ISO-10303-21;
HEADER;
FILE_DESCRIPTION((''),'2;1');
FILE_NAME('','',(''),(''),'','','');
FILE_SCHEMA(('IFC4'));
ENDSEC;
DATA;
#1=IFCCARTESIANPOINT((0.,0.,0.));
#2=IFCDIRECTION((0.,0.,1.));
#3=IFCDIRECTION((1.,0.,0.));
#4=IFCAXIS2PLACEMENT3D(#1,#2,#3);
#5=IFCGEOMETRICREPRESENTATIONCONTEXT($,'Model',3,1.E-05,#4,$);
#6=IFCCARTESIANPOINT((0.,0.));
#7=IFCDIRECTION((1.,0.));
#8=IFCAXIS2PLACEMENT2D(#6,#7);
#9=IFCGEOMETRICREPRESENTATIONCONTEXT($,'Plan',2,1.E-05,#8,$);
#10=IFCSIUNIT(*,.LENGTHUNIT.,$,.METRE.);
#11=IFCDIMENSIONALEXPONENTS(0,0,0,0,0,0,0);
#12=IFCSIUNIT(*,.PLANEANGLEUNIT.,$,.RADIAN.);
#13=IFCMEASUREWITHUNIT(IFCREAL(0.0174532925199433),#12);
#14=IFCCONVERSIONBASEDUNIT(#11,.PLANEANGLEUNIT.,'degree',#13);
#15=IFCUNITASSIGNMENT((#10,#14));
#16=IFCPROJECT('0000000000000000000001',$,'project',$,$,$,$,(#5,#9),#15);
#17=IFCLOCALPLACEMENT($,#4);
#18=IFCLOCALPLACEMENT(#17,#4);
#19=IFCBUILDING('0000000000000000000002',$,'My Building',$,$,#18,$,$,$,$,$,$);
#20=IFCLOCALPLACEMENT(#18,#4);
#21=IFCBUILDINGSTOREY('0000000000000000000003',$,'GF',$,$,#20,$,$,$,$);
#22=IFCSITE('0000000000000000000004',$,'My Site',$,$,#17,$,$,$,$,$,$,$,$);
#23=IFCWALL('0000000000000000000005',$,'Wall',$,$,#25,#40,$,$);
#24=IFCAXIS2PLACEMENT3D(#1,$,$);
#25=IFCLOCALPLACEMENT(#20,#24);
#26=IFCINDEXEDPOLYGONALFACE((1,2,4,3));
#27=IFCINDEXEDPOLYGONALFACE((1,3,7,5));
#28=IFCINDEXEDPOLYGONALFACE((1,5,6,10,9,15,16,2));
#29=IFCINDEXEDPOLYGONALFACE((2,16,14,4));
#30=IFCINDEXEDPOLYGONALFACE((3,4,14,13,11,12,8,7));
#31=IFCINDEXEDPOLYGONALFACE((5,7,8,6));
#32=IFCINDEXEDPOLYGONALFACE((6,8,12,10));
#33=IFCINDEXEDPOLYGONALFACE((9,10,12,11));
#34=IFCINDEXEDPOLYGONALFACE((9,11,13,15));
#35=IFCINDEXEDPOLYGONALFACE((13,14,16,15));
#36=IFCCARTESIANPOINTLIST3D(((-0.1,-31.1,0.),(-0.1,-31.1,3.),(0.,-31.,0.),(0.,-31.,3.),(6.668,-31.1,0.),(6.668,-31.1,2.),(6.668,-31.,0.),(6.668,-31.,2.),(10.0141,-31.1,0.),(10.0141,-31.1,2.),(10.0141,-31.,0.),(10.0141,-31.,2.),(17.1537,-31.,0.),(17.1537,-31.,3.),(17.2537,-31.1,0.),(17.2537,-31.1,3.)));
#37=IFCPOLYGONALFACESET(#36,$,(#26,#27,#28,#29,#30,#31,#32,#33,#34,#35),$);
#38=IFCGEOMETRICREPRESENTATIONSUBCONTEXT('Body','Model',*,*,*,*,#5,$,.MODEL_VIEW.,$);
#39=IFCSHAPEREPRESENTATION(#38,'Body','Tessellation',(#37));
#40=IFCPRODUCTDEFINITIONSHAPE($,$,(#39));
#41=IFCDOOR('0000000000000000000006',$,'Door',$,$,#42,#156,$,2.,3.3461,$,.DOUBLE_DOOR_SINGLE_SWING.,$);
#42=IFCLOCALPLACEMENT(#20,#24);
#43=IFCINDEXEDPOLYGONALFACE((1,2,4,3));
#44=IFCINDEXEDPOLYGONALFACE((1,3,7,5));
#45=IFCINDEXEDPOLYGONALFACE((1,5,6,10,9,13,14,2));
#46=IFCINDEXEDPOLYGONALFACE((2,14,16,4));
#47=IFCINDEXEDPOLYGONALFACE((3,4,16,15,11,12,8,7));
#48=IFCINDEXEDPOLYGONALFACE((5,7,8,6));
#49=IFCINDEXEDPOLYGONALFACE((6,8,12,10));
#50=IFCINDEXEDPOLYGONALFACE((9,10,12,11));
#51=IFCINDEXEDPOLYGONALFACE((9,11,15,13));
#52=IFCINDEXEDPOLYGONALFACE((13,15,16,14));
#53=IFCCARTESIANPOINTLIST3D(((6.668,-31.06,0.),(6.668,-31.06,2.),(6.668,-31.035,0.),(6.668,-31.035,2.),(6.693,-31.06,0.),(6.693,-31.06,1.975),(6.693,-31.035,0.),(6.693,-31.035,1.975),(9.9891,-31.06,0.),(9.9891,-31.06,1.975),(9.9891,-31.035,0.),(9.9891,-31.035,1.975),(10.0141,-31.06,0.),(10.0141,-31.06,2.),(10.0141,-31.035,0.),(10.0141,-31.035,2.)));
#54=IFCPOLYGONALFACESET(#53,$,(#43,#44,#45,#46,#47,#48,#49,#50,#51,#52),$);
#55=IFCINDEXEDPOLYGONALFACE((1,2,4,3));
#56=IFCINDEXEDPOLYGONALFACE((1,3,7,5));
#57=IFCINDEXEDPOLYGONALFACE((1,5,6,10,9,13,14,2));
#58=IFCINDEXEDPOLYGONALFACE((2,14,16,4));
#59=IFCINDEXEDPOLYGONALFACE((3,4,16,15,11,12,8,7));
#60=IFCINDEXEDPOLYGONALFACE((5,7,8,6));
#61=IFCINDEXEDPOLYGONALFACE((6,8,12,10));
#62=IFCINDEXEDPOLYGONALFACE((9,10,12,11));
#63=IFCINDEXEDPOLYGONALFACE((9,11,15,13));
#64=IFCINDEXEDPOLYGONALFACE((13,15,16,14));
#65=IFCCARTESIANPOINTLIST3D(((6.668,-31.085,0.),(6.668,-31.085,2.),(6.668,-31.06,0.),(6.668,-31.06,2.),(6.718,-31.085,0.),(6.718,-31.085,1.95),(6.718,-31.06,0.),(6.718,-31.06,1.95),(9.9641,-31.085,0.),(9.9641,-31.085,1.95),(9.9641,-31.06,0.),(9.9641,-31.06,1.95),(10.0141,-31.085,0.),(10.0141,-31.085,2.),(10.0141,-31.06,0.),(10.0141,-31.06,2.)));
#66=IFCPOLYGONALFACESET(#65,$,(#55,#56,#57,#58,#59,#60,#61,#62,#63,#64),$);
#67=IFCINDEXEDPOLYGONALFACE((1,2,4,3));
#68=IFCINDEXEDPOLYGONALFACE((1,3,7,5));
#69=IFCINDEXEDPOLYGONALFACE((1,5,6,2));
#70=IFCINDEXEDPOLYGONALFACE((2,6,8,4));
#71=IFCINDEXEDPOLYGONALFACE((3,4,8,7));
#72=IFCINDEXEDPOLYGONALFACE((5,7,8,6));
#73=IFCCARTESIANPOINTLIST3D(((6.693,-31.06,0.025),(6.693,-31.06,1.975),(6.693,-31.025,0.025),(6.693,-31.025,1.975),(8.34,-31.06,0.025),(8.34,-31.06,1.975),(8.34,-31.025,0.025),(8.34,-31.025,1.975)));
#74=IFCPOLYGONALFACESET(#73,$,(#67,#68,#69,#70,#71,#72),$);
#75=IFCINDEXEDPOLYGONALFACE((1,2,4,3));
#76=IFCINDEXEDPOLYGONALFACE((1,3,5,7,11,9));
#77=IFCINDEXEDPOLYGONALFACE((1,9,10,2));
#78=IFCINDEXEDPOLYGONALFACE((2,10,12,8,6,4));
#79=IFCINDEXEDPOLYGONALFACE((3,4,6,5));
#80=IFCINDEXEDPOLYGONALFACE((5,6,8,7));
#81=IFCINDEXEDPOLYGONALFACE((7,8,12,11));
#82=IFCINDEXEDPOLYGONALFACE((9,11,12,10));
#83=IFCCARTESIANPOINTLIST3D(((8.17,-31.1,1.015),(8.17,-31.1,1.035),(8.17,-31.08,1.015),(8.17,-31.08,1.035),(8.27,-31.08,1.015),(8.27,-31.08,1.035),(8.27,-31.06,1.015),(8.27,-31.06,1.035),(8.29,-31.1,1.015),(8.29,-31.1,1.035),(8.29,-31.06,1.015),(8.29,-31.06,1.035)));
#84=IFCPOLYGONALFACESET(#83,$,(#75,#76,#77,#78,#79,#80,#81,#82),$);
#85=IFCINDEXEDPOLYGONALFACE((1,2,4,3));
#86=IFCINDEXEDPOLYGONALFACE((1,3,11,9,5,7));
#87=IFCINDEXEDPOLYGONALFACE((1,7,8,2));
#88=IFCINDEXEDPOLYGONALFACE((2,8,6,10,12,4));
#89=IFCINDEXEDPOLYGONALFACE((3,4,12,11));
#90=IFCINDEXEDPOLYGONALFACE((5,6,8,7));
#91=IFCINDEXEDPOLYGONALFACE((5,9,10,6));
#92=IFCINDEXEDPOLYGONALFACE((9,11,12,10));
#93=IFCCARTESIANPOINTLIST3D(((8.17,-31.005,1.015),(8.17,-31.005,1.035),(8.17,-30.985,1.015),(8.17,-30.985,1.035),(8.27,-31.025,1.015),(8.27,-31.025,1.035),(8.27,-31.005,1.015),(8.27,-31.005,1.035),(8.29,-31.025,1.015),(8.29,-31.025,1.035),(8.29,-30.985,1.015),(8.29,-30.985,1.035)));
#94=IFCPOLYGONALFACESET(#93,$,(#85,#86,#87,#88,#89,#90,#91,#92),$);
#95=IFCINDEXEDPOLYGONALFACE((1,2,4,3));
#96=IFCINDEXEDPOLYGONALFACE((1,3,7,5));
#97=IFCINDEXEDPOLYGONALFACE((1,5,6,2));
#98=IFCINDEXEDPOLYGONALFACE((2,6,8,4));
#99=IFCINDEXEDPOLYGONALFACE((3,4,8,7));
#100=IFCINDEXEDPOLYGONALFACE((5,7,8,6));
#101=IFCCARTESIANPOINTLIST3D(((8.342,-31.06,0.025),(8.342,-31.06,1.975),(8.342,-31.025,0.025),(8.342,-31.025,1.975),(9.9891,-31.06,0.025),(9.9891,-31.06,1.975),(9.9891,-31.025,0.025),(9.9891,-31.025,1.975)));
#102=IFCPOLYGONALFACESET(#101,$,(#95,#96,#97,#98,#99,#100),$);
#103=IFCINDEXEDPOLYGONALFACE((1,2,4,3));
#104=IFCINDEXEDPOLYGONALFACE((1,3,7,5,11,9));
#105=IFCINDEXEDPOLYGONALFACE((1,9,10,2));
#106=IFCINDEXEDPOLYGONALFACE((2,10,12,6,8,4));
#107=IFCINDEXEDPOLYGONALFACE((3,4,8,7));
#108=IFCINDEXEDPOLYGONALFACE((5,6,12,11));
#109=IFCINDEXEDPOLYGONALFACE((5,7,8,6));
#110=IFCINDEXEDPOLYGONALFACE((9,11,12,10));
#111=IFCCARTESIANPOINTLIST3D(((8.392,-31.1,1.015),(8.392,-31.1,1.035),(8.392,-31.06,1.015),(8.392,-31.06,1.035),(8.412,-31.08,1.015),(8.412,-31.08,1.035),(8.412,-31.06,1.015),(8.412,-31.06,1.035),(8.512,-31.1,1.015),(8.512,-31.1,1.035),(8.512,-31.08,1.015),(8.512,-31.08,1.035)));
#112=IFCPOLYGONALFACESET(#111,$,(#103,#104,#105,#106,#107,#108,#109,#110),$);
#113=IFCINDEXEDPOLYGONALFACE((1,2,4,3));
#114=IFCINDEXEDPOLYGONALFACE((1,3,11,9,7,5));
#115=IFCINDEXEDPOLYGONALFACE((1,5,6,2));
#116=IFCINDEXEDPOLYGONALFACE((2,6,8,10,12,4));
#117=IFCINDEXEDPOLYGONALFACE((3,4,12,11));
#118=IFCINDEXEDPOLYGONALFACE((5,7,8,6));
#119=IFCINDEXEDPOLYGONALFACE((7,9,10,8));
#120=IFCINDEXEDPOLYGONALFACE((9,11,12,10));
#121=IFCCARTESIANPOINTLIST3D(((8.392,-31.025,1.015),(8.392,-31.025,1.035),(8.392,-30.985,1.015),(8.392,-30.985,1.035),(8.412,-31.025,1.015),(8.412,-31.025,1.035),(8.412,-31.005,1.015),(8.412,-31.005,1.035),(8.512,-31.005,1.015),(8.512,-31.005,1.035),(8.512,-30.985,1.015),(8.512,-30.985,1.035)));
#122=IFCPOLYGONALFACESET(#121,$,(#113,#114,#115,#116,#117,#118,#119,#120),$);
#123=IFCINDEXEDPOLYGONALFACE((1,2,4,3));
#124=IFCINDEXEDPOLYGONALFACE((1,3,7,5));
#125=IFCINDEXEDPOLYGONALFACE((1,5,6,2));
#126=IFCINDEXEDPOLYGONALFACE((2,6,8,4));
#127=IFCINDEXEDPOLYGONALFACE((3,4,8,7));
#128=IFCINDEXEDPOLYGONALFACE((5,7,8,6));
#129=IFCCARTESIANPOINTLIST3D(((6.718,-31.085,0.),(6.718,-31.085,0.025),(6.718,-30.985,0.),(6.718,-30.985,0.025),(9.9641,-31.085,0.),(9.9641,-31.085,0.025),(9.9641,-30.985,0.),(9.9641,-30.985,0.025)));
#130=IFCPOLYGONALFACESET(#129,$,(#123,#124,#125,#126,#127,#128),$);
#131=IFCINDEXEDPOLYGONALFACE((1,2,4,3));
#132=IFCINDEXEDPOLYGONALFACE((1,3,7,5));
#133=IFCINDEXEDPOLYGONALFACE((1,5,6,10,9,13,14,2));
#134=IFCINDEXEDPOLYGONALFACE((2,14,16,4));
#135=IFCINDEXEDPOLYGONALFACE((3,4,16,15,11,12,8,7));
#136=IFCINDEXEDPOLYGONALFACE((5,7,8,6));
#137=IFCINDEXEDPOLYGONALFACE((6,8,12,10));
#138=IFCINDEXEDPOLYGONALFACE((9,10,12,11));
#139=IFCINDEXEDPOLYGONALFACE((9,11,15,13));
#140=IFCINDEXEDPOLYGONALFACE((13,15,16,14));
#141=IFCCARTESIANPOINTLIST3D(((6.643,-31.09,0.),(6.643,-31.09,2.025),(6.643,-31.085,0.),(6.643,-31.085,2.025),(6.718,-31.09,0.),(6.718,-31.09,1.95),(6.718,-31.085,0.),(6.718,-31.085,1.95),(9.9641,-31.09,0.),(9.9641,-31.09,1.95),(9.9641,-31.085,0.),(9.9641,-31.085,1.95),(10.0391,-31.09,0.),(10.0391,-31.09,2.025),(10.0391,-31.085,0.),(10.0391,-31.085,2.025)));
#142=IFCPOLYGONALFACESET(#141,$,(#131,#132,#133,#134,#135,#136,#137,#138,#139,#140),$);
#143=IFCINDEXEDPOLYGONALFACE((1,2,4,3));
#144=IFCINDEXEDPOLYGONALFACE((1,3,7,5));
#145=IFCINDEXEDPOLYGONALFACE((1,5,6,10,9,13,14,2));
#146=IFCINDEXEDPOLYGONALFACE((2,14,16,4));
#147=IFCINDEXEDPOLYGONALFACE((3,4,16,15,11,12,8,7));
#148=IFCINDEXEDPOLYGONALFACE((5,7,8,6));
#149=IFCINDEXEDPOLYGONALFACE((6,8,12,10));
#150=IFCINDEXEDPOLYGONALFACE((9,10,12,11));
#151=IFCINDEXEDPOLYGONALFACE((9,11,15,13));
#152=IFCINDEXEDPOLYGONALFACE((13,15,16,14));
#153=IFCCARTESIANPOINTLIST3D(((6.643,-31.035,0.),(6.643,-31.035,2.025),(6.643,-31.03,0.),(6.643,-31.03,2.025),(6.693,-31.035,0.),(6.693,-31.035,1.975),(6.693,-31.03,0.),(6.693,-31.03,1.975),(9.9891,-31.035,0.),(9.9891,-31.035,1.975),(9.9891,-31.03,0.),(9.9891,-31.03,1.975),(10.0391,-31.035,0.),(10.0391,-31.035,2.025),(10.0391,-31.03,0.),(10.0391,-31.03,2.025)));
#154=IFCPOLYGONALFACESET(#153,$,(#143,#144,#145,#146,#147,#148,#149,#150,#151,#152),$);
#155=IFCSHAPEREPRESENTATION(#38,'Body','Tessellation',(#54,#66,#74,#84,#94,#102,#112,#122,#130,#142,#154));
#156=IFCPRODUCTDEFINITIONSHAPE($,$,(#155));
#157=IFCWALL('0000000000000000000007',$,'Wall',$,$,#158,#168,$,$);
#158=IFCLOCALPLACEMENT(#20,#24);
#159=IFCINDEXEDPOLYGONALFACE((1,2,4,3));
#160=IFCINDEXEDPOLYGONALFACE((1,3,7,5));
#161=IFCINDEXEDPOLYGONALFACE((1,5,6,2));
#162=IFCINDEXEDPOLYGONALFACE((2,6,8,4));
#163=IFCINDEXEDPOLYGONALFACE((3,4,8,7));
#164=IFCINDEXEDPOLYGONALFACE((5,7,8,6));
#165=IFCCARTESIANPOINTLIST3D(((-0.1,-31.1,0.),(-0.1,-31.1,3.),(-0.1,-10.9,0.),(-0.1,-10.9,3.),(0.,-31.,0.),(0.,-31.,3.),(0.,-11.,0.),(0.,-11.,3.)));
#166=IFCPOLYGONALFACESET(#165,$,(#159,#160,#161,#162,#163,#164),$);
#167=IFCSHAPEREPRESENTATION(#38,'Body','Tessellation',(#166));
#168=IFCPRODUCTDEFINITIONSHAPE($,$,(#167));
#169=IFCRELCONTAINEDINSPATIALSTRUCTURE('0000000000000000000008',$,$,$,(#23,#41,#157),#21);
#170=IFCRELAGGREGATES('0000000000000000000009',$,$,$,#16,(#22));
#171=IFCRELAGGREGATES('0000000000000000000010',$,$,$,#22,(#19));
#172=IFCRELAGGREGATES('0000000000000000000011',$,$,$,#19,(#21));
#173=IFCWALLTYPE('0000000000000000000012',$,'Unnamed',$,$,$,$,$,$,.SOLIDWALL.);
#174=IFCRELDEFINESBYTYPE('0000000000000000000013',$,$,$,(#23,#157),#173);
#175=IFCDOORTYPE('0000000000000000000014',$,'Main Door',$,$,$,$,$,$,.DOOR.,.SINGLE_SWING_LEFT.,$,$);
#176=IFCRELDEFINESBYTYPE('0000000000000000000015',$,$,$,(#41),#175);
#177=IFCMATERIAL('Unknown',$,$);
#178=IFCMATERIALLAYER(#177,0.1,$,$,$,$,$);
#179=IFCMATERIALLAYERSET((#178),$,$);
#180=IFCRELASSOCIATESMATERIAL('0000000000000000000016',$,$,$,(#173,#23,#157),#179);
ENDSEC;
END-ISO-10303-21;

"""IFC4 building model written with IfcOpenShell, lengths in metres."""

from ifc_helpers import new_model, entity, si_unit, converted_unit, frame, origin_with_axes, origin_2d_with_axis, place, context, subcontext, project, spatial, line, indexed_curve, outline, extrude, shape, source, transform, mapped, material, layer, layer_set, layer_usage, type_object, type_shapes, element, fill, save


model = new_model("IFC4")

# Units and contexts
model_context = context("Model", 3, precision=1e-05, world=origin_with_axes())
plan_context = context("Plan", 2, precision=1e-05, world=origin_2d_with_axis())
body_context_1 = subcontext(model_context, "Body", "Model", "MODEL_VIEW")
body_context_2 = subcontext(plan_context, "Body", "Plan", "PLAN_VIEW")
ifc_project = project(units=[si_unit("LENGTHUNIT", "METRE"), converted_unit("PLANEANGLEUNIT", "degree", entity("IfcReal", 0.0174532925199433), si_unit("PLANEANGLEUNIT", "RADIAN"), dimensions=[0, 0, 0, 0, 0, 0, 0])], contexts=[model_context, plan_context])

# Site, building, storey
site_placement = place(None, origin_with_axes())
site = spatial("IfcSite", under=ifc_project, at=site_placement, Name="My Site")
building_placement = place(site_placement, origin_with_axes())
building = spatial("IfcBuilding", under=site, at=building_placement, Name="My Building")
storey_placement = place(building_placement, origin_with_axes())
storey = spatial("IfcBuildingStorey", under=building, at=storey_placement, Name="GF")

# Shared definitions
ifc_material = material(Name="Unknown")

# Shared definitions
ifc_layer_1 = layer(ifc_material, 0.1)
ifc_layer_set_1 = layer_set([ifc_layer_1])
wall_type = type_object("IfcWallType", Name="Unnamed", PredefinedType="SOLIDWALL", material=ifc_layer_set_1)

# Wall, opening, door
ifc_layer_usage_1 = layer_usage(ifc_layer_set_1, "AXIS2", "POSITIVE", 0.0)
wall_1_placement = place(storey_placement, frame((17.1537, -31.0, 0.0), z_axis=(0.0, 0.0, 1.0), x_axis=(-1.0, 0.0, 0.0)))
wall_1 = element("IfcWall", 1, at=wall_1_placement, inside=storey, type_object=wall_type, material=ifc_layer_usage_1, Name="Wall", context=body_context_1, shape_type="SweptSolid", body=[
    extrude(outline(indexed_curve([(0.0, 0.0), (-0.1, 0.1), (17.2537, 0.1), (17.1537, 0.0)], segments=[line(1, 2, 3, 4, 1)])), origin_with_axes(), (0.0, 0.0, 1.0), 3.0),
])
shared_shape_1 = source(origin_with_axes(), body_context_1, "Body", "SweptSolid", [
    extrude(outline(indexed_curve([(0.0, 0.0), (3.3461, 0.0), (3.3461, 2.0), (0.0, 2.0)], segments=[line(1, 2, 3, 4, 1)])), frame((0.0, -0.6, 0.0), z_axis=(0.0, -1.0, 0.0), x_axis=(1.0, 0.0, 0.0)), (0.0, 0.0, -1.0), 1.2),
])
opening_1_placement = place(wall_1_placement, frame((10.4857, 0.085, 0.0), z_axis=(0.0, 0.0, 1.0), x_axis=(-1.0, 0.0, 0.0)))
opening_1 = element("IfcOpeningElement", 2, at=opening_1_placement, cuts=wall_1, PredefinedType="OPENING", context=body_context_1, shape_type="MappedRepresentation", body=[
    mapped(shared_shape_1, transform((0.0, 0.0, 0.0), x_axis=(1.0, 0.0, 0.0), y_axis=(0.0, 1.0, 0.0), z_axis=(0.0, 0.0, 1.0), scale=1.0)),
])
door_type_1 = type_object("IfcDoorType", Name="Main Door", OperationType="SINGLE_SWING_LEFT", PredefinedType="DOOR")
shared_shape_2 = source(origin_with_axes(), body_context_1, "Body", "SweptSolid", [
    extrude(outline(indexed_curve([(0.0, 0.0), (0.0, 2.0), (3.3461, 2.0), (3.3461, 0.0), (3.3211, 0.0), (3.3211, 1.975), (0.025, 1.975), (0.025, 0.0)], segments=[line(1, 2, 3, 4, 5, 6, 7, 8, 1)])), frame((0.0, 0.025, 0.0), z_axis=(0.0, -1.0, 0.0), x_axis=(1.0, 0.0, 0.0)), (0.0, 0.0, -1.0), 0.025),
    extrude(outline(indexed_curve([(0.0, 0.0), (0.0, 2.0), (3.3461, 2.0), (3.3461, 0.0), (3.2961, 0.0), (3.2961, 1.95), (0.05, 1.95), (0.05, 0.0)], segments=[line(1, 2, 3, 4, 5, 6, 7, 8, 1)])), frame((0.0, 0.0, 0.0), z_axis=(0.0, -1.0, 0.0), x_axis=(1.0, 0.0, 0.0)), (0.0, 0.0, -1.0), 0.025),
    extrude(outline(indexed_curve([(0.0, 0.0), (1.647, 0.0), (1.647, 0.035), (0.0, 0.035)], segments=[line(1, 2, 3, 4, 1)])), frame((0.025, 0.025, 0.025), z_axis=(0.0, 0.0, 1.0), x_axis=(1.0, 0.0, 0.0)), (0.0, 0.0, 1.0), 1.95),
    extrude(outline(indexed_curve([(0.0, 0.0), (0.0, -0.04), (-0.12, -0.04), (-0.12, -0.02), (-0.02, -0.02), (-0.02, 0.0)], segments=[line(1, 2, 3, 4, 5, 6, 1)])), frame((1.622, 0.025, 1.015), z_axis=(0.0, 0.0, 1.0), x_axis=(1.0, 0.0, 0.0)), (0.0, 0.0, 1.0), 0.02),
    extrude(outline(indexed_curve([(0.0, 0.0), (0.0, 0.04), (-0.12, 0.04), (-0.12, 0.02), (-0.02, 0.02), (-0.02, 0.0)], segments=[line(1, 2, 3, 4, 5, 6, 1)])), frame((1.622, 0.06, 1.015), z_axis=(0.0, 0.0, 1.0), x_axis=(1.0, 0.0, 0.0)), (0.0, 0.0, 1.0), 0.02),
    extrude(outline(indexed_curve([(0.0, 0.0), (-1.647, 0.0), (-1.647, 0.035), (0.0, 0.035)], segments=[line(1, 2, 3, 4, 1)])), frame((3.3211, 0.025, 0.025), z_axis=(0.0, 0.0, 1.0), x_axis=(1.0, 0.0, 0.0)), (0.0, 0.0, 1.0), 1.95),
    extrude(outline(indexed_curve([(0.0, 0.0), (0.0, -0.04), (0.12, -0.04), (0.12, -0.02), (0.02, -0.02), (0.02, 0.0)], segments=[line(1, 2, 3, 4, 5, 6, 1)])), frame((1.724, 0.025, 1.015), z_axis=(0.0, 0.0, 1.0), x_axis=(1.0, 0.0, 0.0)), (0.0, 0.0, 1.0), 0.02),
    extrude(outline(indexed_curve([(0.0, 0.0), (0.0, 0.04), (0.12, 0.04), (0.12, 0.02), (0.02, 0.02), (0.02, 0.0)], segments=[line(1, 2, 3, 4, 5, 6, 1)])), frame((1.724, 0.06, 1.015), z_axis=(0.0, 0.0, 1.0), x_axis=(1.0, 0.0, 0.0)), (0.0, 0.0, 1.0), 0.02),
    extrude(outline(indexed_curve([(0.0, 0.0), (3.2461, 0.0), (3.2461, 0.1), (0.0, 0.1)], segments=[line(1, 2, 3, 4, 1)])), frame((0.05, 0.0, 0.0), z_axis=(0.0, 0.0, 1.0), x_axis=(1.0, 0.0, 0.0)), (0.0, 0.0, 1.0), 0.025),
    extrude(outline(indexed_curve([(0.0, 0.0), (0.0, 2.025), (3.3961, 2.025), (3.3961, 0.0), (3.3211, 0.0), (3.3211, 1.95), (0.075, 1.95), (0.075, 0.0)], segments=[line(1, 2, 3, 4, 5, 6, 7, 8, 1)])), frame((-0.025, -0.005, 0.0), z_axis=(0.0, -1.0, 0.0), x_axis=(1.0, 0.0, 0.0)), (0.0, 0.0, -1.0), 0.005),
    extrude(outline(indexed_curve([(0.0, 0.0), (0.0, 2.025), (3.3961, 2.025), (3.3961, 0.0), (3.3461, 0.0), (3.3461, 1.975), (0.05, 1.975), (0.05, 0.0)], segments=[line(1, 2, 3, 4, 5, 6, 7, 8, 1)])), frame((-0.025, 0.05, 0.0), z_axis=(0.0, -1.0, 0.0), x_axis=(1.0, 0.0, 0.0)), (0.0, 0.0, -1.0), 0.005),
])
shared_shape_3 = source(origin_with_axes(), body_context_2, "Body", "Curve2D", [
    entity("IfcIndexedPolyCurve", entity("IfcCartesianPointList2D", [[0.0, 0.0], [0.0, 0.05], [0.025, 0.05], [0.025, 0.025], [0.05, 0.025], [0.05, 0.0]]), [entity("IfcLineIndex", [1, 2, 3, 4, 5, 6, 1])]),
    entity("IfcIndexedPolyCurve", entity("IfcCartesianPointList2D", [[3.3461, 0.0], [3.3461, 0.05], [3.3211, 0.05], [3.3211, 0.025], [3.2961, 0.025], [3.2961, 0.0]]), [entity("IfcLineIndex", [1, 2, 3, 4, 5, 6, 1])]),
    entity("IfcTrimmedCurve", entity("IfcEllipse", entity("IfcAxis2Placement2D", entity("IfcCartesianPoint", [0.06, 0.05]), entity("IfcDirection", [1.0, 0.0])), 1.613, 1.648), [entity("IfcCartesianPoint", [1.673, 0.05])], [entity("IfcCartesianPoint", [0.06, 1.698])], True, "CARTESIAN"),
    entity("IfcIndexedPolyCurve", entity("IfcCartesianPointList2D", [[0.025, 0.05], [0.06, 0.05], [0.06, 1.698], [0.025, 1.698]]), [entity("IfcLineIndex", [1, 2, 3, 4, 1])]),
    entity("IfcTrimmedCurve", entity("IfcEllipse", entity("IfcAxis2Placement2D", entity("IfcCartesianPoint", [3.2861, 0.05]), entity("IfcDirection", [1.0, 0.0])), 1.613, 1.648), [entity("IfcCartesianPoint", [3.2861, 1.698])], [entity("IfcCartesianPoint", [1.673, 0.05])], True, "CARTESIAN"),
    entity("IfcIndexedPolyCurve", entity("IfcCartesianPointList2D", [[3.3211, 0.05], [3.2861, 0.05], [3.2861, 1.698], [3.3211, 1.698]]), [entity("IfcLineIndex", [1, 2, 3, 4, 1])]),
])
type_shapes(door_type_1, [shared_shape_2, shared_shape_3])
door_1_placement = place(opening_1_placement, frame((0.0, 0.0, 0.0), z_axis=(0.0, 0.0, 1.0), x_axis=(1.0, 0.0, 0.0)))
door_1 = element("IfcDoor", 3, at=door_1_placement, inside=storey, type_object=door_type_1, Name="Door", OperationType="DOUBLE_DOOR_SINGLE_SWING", OverallHeight=2.0, OverallWidth=3.3461, shapes=[
    shape(body_context_1, "Body", "MappedRepresentation", [mapped(shared_shape_2, transform((0.0, 0.0, 0.0), x_axis=(1.0, 0.0, 0.0), y_axis=(0.0, 1.0, 0.0), z_axis=(0.0, 0.0, 1.0), scale=1.0))]),
    shape(body_context_2, "Body", "MappedRepresentation", [mapped(shared_shape_3, transform((0.0, 0.0, 0.0), x_axis=(1.0, 0.0, 0.0), y_axis=(0.0, 1.0, 0.0), z_axis=(0.0, 0.0, 1.0), scale=1.0))]),
])
fill(opening_1, door_1)

# Wall
ifc_layer_usage_2 = layer_usage(ifc_layer_set_1, "AXIS2", "POSITIVE", 0.0)
wall_2_placement = place(storey_placement, frame((0.0, -31.0, 0.0), z_axis=(0.0, 0.0, 1.0), x_axis=(0.0, 1.0, 0.0)))
element("IfcWall", 4, at=wall_2_placement, inside=storey, type_object=wall_type, material=ifc_layer_usage_2, Name="Wall", context=body_context_1, shape_type="SweptSolid", body=[
    extrude(outline(indexed_curve([(0.0, 0.0), (-0.1, 0.1), (20.1, 0.1), (20.0, 0.0)], segments=[line(1, 2, 3, 4, 1)])), origin_with_axes(), (0.0, 0.0, 1.0), 3.0),
])

save(model, "model.ifc")
